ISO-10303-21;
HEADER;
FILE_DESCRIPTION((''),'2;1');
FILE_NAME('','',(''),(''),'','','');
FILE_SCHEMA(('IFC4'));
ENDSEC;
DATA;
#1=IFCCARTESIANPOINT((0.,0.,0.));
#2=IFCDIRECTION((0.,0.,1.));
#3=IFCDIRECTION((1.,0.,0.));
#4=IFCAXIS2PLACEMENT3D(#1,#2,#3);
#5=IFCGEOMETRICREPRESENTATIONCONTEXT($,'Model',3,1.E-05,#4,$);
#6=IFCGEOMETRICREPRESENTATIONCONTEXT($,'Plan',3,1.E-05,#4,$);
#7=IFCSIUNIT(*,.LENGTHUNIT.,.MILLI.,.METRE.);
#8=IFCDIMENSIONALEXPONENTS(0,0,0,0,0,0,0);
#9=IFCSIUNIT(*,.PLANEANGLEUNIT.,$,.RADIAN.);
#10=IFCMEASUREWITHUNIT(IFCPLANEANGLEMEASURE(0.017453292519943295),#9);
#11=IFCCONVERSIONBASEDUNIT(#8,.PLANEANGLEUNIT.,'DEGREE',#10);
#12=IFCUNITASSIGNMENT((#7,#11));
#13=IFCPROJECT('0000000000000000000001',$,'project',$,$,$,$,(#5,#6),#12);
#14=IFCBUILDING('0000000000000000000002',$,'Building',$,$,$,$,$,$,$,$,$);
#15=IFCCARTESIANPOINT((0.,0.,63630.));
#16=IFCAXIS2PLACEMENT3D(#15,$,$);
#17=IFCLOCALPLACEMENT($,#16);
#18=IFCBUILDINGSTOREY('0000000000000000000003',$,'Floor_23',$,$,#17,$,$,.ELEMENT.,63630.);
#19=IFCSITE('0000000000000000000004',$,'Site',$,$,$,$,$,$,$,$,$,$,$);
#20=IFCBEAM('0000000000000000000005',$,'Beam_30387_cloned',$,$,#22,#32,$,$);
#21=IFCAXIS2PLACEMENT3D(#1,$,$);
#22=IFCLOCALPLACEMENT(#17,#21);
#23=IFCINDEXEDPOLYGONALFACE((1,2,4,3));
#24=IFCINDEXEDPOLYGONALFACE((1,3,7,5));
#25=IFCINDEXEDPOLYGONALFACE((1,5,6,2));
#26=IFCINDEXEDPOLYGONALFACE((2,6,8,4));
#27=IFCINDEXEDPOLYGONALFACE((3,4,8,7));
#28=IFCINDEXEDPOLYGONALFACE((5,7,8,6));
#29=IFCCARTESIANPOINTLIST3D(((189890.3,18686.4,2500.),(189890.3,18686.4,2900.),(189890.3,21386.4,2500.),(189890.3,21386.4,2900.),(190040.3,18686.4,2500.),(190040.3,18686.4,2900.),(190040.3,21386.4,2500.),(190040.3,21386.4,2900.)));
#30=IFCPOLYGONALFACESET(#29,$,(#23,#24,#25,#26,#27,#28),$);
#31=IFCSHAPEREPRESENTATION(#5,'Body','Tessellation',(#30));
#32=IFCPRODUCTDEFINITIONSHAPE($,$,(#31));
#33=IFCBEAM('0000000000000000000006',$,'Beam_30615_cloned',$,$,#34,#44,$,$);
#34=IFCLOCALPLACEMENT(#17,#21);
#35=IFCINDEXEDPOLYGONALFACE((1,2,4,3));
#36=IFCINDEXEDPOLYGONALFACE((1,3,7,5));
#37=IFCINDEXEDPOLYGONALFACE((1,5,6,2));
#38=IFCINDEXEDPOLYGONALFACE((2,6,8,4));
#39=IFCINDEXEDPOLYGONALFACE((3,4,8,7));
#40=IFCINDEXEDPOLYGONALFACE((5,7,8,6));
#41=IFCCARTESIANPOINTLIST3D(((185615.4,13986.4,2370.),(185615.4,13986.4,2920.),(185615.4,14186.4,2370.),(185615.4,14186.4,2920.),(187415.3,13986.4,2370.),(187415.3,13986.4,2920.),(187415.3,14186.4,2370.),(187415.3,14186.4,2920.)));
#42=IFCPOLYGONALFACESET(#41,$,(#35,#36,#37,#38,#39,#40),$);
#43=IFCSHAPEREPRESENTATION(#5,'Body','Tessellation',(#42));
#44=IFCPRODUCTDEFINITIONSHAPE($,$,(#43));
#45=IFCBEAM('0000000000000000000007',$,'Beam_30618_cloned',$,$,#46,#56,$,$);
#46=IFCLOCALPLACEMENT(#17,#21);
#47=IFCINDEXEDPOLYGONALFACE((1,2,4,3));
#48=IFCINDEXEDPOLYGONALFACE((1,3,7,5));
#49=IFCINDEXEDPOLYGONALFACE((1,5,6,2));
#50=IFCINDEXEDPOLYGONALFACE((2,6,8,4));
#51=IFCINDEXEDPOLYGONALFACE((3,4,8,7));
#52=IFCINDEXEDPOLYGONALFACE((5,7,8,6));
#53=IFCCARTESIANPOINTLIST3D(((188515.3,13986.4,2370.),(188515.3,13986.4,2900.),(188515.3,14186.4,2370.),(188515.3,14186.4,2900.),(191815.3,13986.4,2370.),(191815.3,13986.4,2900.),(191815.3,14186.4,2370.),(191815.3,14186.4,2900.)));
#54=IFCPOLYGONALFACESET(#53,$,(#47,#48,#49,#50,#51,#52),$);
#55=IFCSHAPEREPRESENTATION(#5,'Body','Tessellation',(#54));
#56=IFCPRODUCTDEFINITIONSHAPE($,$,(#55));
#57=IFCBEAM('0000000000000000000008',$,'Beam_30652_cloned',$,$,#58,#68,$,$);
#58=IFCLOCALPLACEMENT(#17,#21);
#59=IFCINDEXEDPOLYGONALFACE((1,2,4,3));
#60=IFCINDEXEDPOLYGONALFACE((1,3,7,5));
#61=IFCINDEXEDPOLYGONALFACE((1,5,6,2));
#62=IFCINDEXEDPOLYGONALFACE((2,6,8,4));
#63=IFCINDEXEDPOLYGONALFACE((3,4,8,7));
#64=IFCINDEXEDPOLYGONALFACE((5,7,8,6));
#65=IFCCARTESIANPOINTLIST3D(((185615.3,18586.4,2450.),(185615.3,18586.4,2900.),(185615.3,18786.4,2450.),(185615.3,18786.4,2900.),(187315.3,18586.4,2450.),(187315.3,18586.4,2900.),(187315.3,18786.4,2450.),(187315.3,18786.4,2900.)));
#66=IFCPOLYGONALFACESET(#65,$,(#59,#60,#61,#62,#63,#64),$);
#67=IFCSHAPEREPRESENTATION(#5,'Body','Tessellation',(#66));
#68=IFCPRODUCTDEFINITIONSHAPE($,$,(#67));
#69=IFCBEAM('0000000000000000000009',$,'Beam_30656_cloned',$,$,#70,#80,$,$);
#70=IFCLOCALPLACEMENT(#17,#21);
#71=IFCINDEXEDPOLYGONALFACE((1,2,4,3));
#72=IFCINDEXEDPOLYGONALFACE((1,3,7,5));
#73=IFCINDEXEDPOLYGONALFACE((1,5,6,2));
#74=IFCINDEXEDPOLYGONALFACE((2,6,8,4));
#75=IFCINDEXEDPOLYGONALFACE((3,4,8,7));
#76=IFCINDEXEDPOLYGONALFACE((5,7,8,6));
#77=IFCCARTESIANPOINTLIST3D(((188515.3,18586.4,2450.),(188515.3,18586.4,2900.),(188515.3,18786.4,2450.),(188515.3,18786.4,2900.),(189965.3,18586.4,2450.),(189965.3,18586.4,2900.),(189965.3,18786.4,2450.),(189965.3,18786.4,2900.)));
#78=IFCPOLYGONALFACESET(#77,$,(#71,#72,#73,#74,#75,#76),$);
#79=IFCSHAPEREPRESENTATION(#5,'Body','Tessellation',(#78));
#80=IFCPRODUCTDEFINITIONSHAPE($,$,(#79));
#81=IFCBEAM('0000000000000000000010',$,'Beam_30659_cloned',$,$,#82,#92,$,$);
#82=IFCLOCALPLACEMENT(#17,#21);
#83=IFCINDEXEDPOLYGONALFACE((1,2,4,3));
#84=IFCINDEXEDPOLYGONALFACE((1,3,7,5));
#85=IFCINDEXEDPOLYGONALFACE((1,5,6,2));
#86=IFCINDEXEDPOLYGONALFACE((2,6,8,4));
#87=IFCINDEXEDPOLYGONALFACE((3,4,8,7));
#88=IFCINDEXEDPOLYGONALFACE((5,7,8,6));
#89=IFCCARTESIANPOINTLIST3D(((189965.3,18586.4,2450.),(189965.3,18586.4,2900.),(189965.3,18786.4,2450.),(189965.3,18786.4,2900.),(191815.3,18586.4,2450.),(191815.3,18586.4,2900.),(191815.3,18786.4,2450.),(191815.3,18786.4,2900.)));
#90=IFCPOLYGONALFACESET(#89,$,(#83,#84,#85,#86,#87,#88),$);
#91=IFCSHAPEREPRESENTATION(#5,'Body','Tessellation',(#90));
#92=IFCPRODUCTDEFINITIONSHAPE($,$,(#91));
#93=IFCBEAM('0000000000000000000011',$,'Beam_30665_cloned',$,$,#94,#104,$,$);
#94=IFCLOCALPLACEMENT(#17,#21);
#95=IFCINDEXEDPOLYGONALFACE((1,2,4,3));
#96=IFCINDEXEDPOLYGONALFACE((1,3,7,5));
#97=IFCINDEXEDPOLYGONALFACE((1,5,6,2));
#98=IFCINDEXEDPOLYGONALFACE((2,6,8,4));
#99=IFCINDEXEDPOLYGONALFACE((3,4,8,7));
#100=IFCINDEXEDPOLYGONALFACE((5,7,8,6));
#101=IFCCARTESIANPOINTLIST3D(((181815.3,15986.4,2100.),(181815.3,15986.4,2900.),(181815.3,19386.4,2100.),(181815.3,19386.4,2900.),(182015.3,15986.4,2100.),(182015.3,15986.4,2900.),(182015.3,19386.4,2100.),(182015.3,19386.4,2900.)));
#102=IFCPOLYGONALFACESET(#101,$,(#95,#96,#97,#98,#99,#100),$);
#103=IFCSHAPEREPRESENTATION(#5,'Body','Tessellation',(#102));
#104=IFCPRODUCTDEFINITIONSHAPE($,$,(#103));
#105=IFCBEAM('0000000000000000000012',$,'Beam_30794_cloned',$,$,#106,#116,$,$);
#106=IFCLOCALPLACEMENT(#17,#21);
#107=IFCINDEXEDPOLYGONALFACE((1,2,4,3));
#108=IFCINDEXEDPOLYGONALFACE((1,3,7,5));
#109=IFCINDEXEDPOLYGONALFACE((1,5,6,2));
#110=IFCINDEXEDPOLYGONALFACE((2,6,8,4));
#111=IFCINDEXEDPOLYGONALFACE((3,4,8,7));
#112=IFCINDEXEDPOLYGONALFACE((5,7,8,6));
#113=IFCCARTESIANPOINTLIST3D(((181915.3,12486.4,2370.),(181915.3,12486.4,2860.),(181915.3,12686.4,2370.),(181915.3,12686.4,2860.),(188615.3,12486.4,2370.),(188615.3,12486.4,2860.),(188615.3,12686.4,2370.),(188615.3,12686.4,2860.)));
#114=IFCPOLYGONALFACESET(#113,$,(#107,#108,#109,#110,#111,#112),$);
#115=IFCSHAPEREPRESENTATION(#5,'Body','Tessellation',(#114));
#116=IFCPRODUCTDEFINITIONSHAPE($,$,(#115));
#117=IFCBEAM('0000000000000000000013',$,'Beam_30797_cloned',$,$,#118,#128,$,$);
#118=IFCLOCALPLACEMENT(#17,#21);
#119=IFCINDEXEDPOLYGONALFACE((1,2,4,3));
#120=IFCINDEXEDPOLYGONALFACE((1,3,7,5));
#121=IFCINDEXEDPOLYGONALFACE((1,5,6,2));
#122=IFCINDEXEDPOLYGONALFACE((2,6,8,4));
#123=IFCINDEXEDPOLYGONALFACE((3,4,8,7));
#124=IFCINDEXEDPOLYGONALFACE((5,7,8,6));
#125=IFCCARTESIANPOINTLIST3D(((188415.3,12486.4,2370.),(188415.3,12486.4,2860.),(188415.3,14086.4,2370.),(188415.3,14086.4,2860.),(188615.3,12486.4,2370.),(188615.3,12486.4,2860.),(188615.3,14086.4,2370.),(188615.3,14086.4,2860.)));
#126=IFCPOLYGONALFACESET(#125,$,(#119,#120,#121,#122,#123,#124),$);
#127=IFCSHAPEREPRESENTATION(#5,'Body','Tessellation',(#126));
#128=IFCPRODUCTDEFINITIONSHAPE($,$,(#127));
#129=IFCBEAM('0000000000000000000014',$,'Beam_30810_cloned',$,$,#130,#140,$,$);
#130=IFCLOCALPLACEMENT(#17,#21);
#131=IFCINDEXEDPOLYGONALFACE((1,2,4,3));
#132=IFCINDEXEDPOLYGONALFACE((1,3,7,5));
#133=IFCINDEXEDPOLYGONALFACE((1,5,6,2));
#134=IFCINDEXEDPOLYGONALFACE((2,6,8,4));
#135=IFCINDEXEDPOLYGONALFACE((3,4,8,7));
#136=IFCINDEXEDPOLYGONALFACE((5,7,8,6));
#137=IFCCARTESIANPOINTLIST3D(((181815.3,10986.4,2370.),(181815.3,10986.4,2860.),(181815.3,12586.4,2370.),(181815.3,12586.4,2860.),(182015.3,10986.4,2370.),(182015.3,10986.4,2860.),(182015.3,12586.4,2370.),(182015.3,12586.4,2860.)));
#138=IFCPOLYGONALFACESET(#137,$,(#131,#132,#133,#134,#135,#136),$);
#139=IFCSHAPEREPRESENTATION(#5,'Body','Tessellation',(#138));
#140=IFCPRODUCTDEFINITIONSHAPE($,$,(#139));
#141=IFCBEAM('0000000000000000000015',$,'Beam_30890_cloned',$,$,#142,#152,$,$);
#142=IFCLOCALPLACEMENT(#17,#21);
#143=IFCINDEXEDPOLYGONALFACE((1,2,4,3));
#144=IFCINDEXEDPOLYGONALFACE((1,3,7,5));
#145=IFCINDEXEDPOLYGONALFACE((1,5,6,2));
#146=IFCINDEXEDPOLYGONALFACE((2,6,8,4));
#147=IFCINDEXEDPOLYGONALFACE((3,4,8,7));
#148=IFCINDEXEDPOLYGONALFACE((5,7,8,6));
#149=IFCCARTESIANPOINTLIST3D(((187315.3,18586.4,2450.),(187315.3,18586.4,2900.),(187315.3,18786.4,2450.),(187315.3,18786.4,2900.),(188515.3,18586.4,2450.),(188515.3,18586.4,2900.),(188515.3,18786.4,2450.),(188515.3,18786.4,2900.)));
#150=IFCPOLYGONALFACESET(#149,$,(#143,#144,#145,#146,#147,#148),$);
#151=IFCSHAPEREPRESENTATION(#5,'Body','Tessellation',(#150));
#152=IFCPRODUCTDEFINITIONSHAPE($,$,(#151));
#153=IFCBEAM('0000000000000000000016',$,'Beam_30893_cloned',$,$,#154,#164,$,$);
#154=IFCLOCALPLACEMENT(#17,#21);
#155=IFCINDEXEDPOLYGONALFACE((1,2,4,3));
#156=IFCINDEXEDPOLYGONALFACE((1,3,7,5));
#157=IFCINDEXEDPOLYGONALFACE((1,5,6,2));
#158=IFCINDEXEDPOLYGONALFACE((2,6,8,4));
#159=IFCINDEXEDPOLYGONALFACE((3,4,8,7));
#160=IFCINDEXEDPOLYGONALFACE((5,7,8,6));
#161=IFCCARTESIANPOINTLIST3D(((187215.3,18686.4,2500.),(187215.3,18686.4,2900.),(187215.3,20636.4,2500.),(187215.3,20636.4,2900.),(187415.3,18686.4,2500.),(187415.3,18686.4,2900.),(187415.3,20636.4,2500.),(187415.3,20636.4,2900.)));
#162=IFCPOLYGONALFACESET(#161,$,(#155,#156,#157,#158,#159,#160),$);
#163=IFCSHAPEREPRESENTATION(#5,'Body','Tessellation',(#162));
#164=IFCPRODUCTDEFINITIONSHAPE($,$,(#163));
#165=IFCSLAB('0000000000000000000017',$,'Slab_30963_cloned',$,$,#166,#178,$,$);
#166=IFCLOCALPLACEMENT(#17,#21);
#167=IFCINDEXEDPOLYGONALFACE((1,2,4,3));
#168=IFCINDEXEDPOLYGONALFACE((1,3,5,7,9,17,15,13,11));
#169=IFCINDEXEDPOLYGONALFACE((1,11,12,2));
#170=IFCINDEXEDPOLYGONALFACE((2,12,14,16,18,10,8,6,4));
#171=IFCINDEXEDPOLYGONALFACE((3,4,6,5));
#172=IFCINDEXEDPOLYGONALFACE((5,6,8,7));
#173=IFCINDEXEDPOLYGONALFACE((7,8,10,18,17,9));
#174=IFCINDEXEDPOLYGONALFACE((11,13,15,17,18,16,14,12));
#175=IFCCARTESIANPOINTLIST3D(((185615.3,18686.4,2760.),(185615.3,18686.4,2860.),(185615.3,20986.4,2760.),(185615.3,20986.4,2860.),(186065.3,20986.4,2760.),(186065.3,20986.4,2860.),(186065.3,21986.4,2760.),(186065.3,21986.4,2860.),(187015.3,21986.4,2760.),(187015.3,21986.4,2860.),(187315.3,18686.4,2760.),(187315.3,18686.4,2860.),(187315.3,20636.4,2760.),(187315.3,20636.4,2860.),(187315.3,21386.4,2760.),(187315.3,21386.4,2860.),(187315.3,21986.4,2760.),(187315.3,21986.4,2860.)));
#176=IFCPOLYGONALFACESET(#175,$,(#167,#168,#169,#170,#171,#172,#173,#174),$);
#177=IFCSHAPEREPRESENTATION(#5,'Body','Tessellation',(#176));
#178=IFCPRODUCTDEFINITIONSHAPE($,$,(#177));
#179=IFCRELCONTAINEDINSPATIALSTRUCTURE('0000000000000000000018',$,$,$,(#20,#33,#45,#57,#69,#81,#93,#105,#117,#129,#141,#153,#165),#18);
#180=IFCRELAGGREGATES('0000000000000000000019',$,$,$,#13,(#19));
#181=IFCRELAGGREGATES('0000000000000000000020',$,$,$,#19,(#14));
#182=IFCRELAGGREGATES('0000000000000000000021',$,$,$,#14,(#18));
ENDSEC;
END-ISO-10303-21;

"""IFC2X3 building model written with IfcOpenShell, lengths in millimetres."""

from ifc_helpers import new_model, entity, si_unit, converted_unit, frame, origin_with_axes, origin_2d, place, context, project, spatial, polyline, rectangle, outline, extrude, source, transform, mapped, element, save


model = new_model("IFC2X3")

# Units and contexts
model_context = context("Model", 3, precision=1e-05, world=origin_with_axes())
plan_context = context("Plan", 3, precision=1e-05, world=origin_with_axes())
ifc_project = project(units=[si_unit("LENGTHUNIT", "METRE", prefix="MILLI"), converted_unit("PLANEANGLEUNIT", "DEGREE", entity("IfcPlaneAngleMeasure", 0.017453292519943295), si_unit("PLANEANGLEUNIT", "RADIAN"), dimensions=[0, 0, 0, 0, 0, 0, 0])], contexts=[model_context, plan_context])

# Site, building, storey
site = spatial("IfcSite", under=ifc_project, Name="Site")
building = spatial("IfcBuilding", under=site, Name="Building")
storey_placement = place(None, frame((0.0, 0.0, 63630.0)))
storey = spatial("IfcBuildingStorey", under=building, at=storey_placement, Name="Floor_23", CompositionType="ELEMENT", Elevation=63630.0)

# Beams
shared_shape_1 = source(origin_with_axes(), model_context, "Body", "SweptSolid", [
    extrude(rectangle(XDim=150.0, YDim=400.0, at=origin_2d()), origin_with_axes(), (0.0, 0.0, 1.0), 2700.0),
])
beam_1_placement = place(storey_placement, frame((189965.3, 18686.4, 2700.0), z_axis=(0.0, 2700.0, 0.0), x_axis=(2700.0, 0.0, 0.0)))
element("IfcBeam", 1, at=beam_1_placement, inside=storey, Name="Beam_30387_cloned", context=model_context, shape_type="MappedRepresentation", body=[
    mapped(shared_shape_1, transform((0.0, 0.0, 0.0), x_axis=(1.0, 0.0, 0.0), y_axis=(0.0, 1.0, 0.0), z_axis=(0.0, 0.0, 1.0), scale=1.0)),
])
shared_shape_2 = source(origin_with_axes(), model_context, "Body", "SweptSolid", [
    extrude(rectangle(XDim=200.0, YDim=550.0, at=origin_2d()), origin_with_axes(), (0.0, 0.0, 1.0), 1799.9),
])
beam_2_placement = place(storey_placement, frame((185615.4, 14086.4, 2645.0), z_axis=(1799.945586, 0.0, 0.0), x_axis=(0.0, -1799.945586, 0.0)))
element("IfcBeam", 2, at=beam_2_placement, inside=storey, Name="Beam_30615_cloned", context=model_context, shape_type="MappedRepresentation", body=[
    mapped(shared_shape_2, transform((0.0, 0.0, 0.0), x_axis=(1.0, 0.0, 0.0), y_axis=(0.0, 1.0, 0.0), z_axis=(0.0, 0.0, 1.0), scale=1.0)),
])
shared_shape_3 = source(origin_with_axes(), model_context, "Body", "SweptSolid", [
    extrude(rectangle(XDim=200.0, YDim=530.0, at=origin_2d()), origin_with_axes(), (0.0, 0.0, 1.0), 3300.0),
])
beam_3_placement = place(storey_placement, frame((188515.3, 14086.4, 2635.0), z_axis=(3299.979202, 0.0, 0.0), x_axis=(0.0, -3299.979202, 0.0)))
element("IfcBeam", 3, at=beam_3_placement, inside=storey, Name="Beam_30618_cloned", context=model_context, shape_type="MappedRepresentation", body=[
    mapped(shared_shape_3, transform((0.0, 0.0, 0.0), x_axis=(1.0, 0.0, 0.0), y_axis=(0.0, 1.0, 0.0), z_axis=(0.0, 0.0, 1.0), scale=1.0)),
])
shared_shape_4 = source(origin_with_axes(), model_context, "Body", "SweptSolid", [
    extrude(rectangle(XDim=200.0, YDim=450.0, at=origin_2d()), origin_with_axes(), (0.0, 0.0, 1.0), 1700.0),
])
beam_4_placement = place(storey_placement, frame((185615.3, 18686.4, 2675.0), z_axis=(1700.0, 0.0, 0.0), x_axis=(0.0, -1700.0, 0.0)))
element("IfcBeam", 4, at=beam_4_placement, inside=storey, Name="Beam_30652_cloned", context=model_context, shape_type="MappedRepresentation", body=[
    mapped(shared_shape_4, transform((0.0, 0.0, 0.0), x_axis=(1.0, 0.0, 0.0), y_axis=(0.0, 1.0, 0.0), z_axis=(0.0, 0.0, 1.0), scale=1.0)),
])
shared_shape_5 = source(origin_with_axes(), model_context, "Body", "SweptSolid", [
    extrude(rectangle(XDim=200.0, YDim=450.0, at=origin_2d()), origin_with_axes(), (0.0, 0.0, 1.0), 1450.0),
])
beam_5_placement = place(storey_placement, frame((188515.3, 18686.4, 2675.0), z_axis=(1449.979201, 0.0, 0.0), x_axis=(0.0, -1449.979201, 0.0)))
element("IfcBeam", 5, at=beam_5_placement, inside=storey, Name="Beam_30656_cloned", context=model_context, shape_type="MappedRepresentation", body=[
    mapped(shared_shape_5, transform((0.0, 0.0, 0.0), x_axis=(1.0, 0.0, 0.0), y_axis=(0.0, 1.0, 0.0), z_axis=(0.0, 0.0, 1.0), scale=1.0)),
])
shared_shape_6 = source(origin_with_axes(), model_context, "Body", "SweptSolid", [
    extrude(rectangle(XDim=200.0, YDim=450.0, at=origin_2d()), origin_with_axes(), (0.0, 0.0, 1.0), 1850.0),
])
beam_6_placement = place(storey_placement, frame((189965.3, 18686.4, 2675.0), z_axis=(1850.0, 0.0, 0.0), x_axis=(0.0, -1850.0, 0.0)))
element("IfcBeam", 6, at=beam_6_placement, inside=storey, Name="Beam_30659_cloned", context=model_context, shape_type="MappedRepresentation", body=[
    mapped(shared_shape_6, transform((0.0, 0.0, 0.0), x_axis=(1.0, 0.0, 0.0), y_axis=(0.0, 1.0, 0.0), z_axis=(0.0, 0.0, 1.0), scale=1.0)),
])
shared_shape_7 = source(origin_with_axes(), model_context, "Body", "SweptSolid", [
    extrude(rectangle(XDim=200.0, YDim=800.0, at=origin_2d()), origin_with_axes(), (0.0, 0.0, 1.0), 3400.0),
])
beam_7_placement = place(storey_placement, frame((181915.3, 15986.4, 2500.0), z_axis=(0.0, 3400.000002, 0.0), x_axis=(3400.000002, 0.0, 0.0)))
element("IfcBeam", 7, at=beam_7_placement, inside=storey, Name="Beam_30665_cloned", context=model_context, shape_type="MappedRepresentation", body=[
    mapped(shared_shape_7, transform((0.0, 0.0, 0.0), x_axis=(1.0, 0.0, 0.0), y_axis=(0.0, 1.0, 0.0), z_axis=(0.0, 0.0, 1.0), scale=1.0)),
])
shared_shape_8 = source(origin_with_axes(), model_context, "Body", "SweptSolid", [
    extrude(rectangle(XDim=200.0, YDim=490.0, at=origin_2d()), origin_with_axes(), (0.0, 0.0, 1.0), 6700.0),
])
beam_8_placement = place(storey_placement, frame((181915.3, 12586.4, 2615.0), z_axis=(6700.020798, 0.0, 0.0), x_axis=(0.0, -6700.020798, 0.0)))
element("IfcBeam", 8, at=beam_8_placement, inside=storey, Name="Beam_30794_cloned", context=model_context, shape_type="MappedRepresentation", body=[
    mapped(shared_shape_8, transform((0.0, 0.0, 0.0), x_axis=(1.0, 0.0, 0.0), y_axis=(0.0, 1.0, 0.0), z_axis=(0.0, 0.0, 1.0), scale=1.0)),
])
shared_shape_9 = source(origin_with_axes(), model_context, "Body", "SweptSolid", [
    extrude(rectangle(XDim=200.0, YDim=490.0, at=origin_2d()), origin_with_axes(), (0.0, 0.0, 1.0), 1600.0),
])
beam_9_placement = place(storey_placement, frame((188515.3, 12486.4, 2615.0), z_axis=(0.0, 1600.000004, 0.0), x_axis=(1600.000004, 0.0, 0.0)))
element("IfcBeam", 9, at=beam_9_placement, inside=storey, Name="Beam_30797_cloned", context=model_context, shape_type="MappedRepresentation", body=[
    mapped(shared_shape_9, transform((0.0, 0.0, 0.0), x_axis=(1.0, 0.0, 0.0), y_axis=(0.0, 1.0, 0.0), z_axis=(0.0, 0.0, 1.0), scale=1.0)),
])
shared_shape_10 = source(origin_with_axes(), model_context, "Body", "SweptSolid", [
    extrude(rectangle(XDim=200.0, YDim=490.0, at=origin_2d()), origin_with_axes(), (0.0, 0.0, 1.0), 1600.0),
])
beam_10_placement = place(storey_placement, frame((181915.3, 10986.4, 2615.0), z_axis=(0.0, 1600.0, 0.0), x_axis=(1600.0, 0.0, 0.0)))
element("IfcBeam", 10, at=beam_10_placement, inside=storey, Name="Beam_30810_cloned", context=model_context, shape_type="MappedRepresentation", body=[
    mapped(shared_shape_10, transform((0.0, 0.0, 0.0), x_axis=(1.0, 0.0, 0.0), y_axis=(0.0, 1.0, 0.0), z_axis=(0.0, 0.0, 1.0), scale=1.0)),
])
shared_shape_11 = source(origin_with_axes(), model_context, "Body", "SweptSolid", [
    extrude(rectangle(XDim=200.0, YDim=450.0, at=origin_2d()), origin_with_axes(), (0.0, 0.0, 1.0), 1200.0),
])
beam_11_placement = place(storey_placement, frame((187315.3, 18686.4, 2675.0), z_axis=(1200.020799, 0.0, 0.0), x_axis=(0.0, -1200.020799, 0.0)))
element("IfcBeam", 11, at=beam_11_placement, inside=storey, Name="Beam_30890_cloned", context=model_context, shape_type="MappedRepresentation", body=[
    mapped(shared_shape_11, transform((0.0, 0.0, 0.0), x_axis=(1.0, 0.0, 0.0), y_axis=(0.0, 1.0, 0.0), z_axis=(0.0, 0.0, 1.0), scale=1.0)),
])
shared_shape_12 = source(origin_with_axes(), model_context, "Body", "SweptSolid", [
    extrude(rectangle(XDim=200.0, YDim=400.0, at=origin_2d()), origin_with_axes(), (0.0, 0.0, 1.0), 1950.0),
])
beam_12_placement = place(storey_placement, frame((187315.3, 18686.4, 2700.0), z_axis=(0.0, 1950.0, 0.0), x_axis=(1950.0, 0.0, 0.0)))
element("IfcBeam", 12, at=beam_12_placement, inside=storey, Name="Beam_30893_cloned", context=model_context, shape_type="MappedRepresentation", body=[
    mapped(shared_shape_12, transform((0.0, 0.0, 0.0), x_axis=(1.0, 0.0, 0.0), y_axis=(0.0, 1.0, 0.0), z_axis=(0.0, 0.0, 1.0), scale=1.0)),
])

# Slab
shared_shape_13 = source(origin_with_axes(), model_context, "Body", "SweptSolid", [
    extrude(outline(polyline([(0.0, 0.0), (1700.0, 0.0), (1700.0, 1950.0), (1700.0, 2700.0), (1700.0, 3300.0), (1400.0, 3300.0), (450.0, 3300.0), (450.0, 2300.0), (0.0, 2300.0)])), origin_with_axes(), (0.0, 0.0, 1.0), 100.0),
])
slab_1_placement = place(storey_placement, frame((185615.3, 18686.4, 2760.0), z_axis=(0.0, 0.0, 1.0), x_axis=(1700.0, 0.0, 0.0)))
element("IfcSlab", 13, at=slab_1_placement, inside=storey, Name="Slab_30963_cloned", context=model_context, shape_type="MappedRepresentation", body=[
    mapped(shared_shape_13, transform((0.0, 0.0, 0.0), x_axis=(1.0, 0.0, 0.0), y_axis=(0.0, 1.0, 0.0), z_axis=(0.0, 0.0, 1.0), scale=1.0)),
])

save(model, "model.ifc")
